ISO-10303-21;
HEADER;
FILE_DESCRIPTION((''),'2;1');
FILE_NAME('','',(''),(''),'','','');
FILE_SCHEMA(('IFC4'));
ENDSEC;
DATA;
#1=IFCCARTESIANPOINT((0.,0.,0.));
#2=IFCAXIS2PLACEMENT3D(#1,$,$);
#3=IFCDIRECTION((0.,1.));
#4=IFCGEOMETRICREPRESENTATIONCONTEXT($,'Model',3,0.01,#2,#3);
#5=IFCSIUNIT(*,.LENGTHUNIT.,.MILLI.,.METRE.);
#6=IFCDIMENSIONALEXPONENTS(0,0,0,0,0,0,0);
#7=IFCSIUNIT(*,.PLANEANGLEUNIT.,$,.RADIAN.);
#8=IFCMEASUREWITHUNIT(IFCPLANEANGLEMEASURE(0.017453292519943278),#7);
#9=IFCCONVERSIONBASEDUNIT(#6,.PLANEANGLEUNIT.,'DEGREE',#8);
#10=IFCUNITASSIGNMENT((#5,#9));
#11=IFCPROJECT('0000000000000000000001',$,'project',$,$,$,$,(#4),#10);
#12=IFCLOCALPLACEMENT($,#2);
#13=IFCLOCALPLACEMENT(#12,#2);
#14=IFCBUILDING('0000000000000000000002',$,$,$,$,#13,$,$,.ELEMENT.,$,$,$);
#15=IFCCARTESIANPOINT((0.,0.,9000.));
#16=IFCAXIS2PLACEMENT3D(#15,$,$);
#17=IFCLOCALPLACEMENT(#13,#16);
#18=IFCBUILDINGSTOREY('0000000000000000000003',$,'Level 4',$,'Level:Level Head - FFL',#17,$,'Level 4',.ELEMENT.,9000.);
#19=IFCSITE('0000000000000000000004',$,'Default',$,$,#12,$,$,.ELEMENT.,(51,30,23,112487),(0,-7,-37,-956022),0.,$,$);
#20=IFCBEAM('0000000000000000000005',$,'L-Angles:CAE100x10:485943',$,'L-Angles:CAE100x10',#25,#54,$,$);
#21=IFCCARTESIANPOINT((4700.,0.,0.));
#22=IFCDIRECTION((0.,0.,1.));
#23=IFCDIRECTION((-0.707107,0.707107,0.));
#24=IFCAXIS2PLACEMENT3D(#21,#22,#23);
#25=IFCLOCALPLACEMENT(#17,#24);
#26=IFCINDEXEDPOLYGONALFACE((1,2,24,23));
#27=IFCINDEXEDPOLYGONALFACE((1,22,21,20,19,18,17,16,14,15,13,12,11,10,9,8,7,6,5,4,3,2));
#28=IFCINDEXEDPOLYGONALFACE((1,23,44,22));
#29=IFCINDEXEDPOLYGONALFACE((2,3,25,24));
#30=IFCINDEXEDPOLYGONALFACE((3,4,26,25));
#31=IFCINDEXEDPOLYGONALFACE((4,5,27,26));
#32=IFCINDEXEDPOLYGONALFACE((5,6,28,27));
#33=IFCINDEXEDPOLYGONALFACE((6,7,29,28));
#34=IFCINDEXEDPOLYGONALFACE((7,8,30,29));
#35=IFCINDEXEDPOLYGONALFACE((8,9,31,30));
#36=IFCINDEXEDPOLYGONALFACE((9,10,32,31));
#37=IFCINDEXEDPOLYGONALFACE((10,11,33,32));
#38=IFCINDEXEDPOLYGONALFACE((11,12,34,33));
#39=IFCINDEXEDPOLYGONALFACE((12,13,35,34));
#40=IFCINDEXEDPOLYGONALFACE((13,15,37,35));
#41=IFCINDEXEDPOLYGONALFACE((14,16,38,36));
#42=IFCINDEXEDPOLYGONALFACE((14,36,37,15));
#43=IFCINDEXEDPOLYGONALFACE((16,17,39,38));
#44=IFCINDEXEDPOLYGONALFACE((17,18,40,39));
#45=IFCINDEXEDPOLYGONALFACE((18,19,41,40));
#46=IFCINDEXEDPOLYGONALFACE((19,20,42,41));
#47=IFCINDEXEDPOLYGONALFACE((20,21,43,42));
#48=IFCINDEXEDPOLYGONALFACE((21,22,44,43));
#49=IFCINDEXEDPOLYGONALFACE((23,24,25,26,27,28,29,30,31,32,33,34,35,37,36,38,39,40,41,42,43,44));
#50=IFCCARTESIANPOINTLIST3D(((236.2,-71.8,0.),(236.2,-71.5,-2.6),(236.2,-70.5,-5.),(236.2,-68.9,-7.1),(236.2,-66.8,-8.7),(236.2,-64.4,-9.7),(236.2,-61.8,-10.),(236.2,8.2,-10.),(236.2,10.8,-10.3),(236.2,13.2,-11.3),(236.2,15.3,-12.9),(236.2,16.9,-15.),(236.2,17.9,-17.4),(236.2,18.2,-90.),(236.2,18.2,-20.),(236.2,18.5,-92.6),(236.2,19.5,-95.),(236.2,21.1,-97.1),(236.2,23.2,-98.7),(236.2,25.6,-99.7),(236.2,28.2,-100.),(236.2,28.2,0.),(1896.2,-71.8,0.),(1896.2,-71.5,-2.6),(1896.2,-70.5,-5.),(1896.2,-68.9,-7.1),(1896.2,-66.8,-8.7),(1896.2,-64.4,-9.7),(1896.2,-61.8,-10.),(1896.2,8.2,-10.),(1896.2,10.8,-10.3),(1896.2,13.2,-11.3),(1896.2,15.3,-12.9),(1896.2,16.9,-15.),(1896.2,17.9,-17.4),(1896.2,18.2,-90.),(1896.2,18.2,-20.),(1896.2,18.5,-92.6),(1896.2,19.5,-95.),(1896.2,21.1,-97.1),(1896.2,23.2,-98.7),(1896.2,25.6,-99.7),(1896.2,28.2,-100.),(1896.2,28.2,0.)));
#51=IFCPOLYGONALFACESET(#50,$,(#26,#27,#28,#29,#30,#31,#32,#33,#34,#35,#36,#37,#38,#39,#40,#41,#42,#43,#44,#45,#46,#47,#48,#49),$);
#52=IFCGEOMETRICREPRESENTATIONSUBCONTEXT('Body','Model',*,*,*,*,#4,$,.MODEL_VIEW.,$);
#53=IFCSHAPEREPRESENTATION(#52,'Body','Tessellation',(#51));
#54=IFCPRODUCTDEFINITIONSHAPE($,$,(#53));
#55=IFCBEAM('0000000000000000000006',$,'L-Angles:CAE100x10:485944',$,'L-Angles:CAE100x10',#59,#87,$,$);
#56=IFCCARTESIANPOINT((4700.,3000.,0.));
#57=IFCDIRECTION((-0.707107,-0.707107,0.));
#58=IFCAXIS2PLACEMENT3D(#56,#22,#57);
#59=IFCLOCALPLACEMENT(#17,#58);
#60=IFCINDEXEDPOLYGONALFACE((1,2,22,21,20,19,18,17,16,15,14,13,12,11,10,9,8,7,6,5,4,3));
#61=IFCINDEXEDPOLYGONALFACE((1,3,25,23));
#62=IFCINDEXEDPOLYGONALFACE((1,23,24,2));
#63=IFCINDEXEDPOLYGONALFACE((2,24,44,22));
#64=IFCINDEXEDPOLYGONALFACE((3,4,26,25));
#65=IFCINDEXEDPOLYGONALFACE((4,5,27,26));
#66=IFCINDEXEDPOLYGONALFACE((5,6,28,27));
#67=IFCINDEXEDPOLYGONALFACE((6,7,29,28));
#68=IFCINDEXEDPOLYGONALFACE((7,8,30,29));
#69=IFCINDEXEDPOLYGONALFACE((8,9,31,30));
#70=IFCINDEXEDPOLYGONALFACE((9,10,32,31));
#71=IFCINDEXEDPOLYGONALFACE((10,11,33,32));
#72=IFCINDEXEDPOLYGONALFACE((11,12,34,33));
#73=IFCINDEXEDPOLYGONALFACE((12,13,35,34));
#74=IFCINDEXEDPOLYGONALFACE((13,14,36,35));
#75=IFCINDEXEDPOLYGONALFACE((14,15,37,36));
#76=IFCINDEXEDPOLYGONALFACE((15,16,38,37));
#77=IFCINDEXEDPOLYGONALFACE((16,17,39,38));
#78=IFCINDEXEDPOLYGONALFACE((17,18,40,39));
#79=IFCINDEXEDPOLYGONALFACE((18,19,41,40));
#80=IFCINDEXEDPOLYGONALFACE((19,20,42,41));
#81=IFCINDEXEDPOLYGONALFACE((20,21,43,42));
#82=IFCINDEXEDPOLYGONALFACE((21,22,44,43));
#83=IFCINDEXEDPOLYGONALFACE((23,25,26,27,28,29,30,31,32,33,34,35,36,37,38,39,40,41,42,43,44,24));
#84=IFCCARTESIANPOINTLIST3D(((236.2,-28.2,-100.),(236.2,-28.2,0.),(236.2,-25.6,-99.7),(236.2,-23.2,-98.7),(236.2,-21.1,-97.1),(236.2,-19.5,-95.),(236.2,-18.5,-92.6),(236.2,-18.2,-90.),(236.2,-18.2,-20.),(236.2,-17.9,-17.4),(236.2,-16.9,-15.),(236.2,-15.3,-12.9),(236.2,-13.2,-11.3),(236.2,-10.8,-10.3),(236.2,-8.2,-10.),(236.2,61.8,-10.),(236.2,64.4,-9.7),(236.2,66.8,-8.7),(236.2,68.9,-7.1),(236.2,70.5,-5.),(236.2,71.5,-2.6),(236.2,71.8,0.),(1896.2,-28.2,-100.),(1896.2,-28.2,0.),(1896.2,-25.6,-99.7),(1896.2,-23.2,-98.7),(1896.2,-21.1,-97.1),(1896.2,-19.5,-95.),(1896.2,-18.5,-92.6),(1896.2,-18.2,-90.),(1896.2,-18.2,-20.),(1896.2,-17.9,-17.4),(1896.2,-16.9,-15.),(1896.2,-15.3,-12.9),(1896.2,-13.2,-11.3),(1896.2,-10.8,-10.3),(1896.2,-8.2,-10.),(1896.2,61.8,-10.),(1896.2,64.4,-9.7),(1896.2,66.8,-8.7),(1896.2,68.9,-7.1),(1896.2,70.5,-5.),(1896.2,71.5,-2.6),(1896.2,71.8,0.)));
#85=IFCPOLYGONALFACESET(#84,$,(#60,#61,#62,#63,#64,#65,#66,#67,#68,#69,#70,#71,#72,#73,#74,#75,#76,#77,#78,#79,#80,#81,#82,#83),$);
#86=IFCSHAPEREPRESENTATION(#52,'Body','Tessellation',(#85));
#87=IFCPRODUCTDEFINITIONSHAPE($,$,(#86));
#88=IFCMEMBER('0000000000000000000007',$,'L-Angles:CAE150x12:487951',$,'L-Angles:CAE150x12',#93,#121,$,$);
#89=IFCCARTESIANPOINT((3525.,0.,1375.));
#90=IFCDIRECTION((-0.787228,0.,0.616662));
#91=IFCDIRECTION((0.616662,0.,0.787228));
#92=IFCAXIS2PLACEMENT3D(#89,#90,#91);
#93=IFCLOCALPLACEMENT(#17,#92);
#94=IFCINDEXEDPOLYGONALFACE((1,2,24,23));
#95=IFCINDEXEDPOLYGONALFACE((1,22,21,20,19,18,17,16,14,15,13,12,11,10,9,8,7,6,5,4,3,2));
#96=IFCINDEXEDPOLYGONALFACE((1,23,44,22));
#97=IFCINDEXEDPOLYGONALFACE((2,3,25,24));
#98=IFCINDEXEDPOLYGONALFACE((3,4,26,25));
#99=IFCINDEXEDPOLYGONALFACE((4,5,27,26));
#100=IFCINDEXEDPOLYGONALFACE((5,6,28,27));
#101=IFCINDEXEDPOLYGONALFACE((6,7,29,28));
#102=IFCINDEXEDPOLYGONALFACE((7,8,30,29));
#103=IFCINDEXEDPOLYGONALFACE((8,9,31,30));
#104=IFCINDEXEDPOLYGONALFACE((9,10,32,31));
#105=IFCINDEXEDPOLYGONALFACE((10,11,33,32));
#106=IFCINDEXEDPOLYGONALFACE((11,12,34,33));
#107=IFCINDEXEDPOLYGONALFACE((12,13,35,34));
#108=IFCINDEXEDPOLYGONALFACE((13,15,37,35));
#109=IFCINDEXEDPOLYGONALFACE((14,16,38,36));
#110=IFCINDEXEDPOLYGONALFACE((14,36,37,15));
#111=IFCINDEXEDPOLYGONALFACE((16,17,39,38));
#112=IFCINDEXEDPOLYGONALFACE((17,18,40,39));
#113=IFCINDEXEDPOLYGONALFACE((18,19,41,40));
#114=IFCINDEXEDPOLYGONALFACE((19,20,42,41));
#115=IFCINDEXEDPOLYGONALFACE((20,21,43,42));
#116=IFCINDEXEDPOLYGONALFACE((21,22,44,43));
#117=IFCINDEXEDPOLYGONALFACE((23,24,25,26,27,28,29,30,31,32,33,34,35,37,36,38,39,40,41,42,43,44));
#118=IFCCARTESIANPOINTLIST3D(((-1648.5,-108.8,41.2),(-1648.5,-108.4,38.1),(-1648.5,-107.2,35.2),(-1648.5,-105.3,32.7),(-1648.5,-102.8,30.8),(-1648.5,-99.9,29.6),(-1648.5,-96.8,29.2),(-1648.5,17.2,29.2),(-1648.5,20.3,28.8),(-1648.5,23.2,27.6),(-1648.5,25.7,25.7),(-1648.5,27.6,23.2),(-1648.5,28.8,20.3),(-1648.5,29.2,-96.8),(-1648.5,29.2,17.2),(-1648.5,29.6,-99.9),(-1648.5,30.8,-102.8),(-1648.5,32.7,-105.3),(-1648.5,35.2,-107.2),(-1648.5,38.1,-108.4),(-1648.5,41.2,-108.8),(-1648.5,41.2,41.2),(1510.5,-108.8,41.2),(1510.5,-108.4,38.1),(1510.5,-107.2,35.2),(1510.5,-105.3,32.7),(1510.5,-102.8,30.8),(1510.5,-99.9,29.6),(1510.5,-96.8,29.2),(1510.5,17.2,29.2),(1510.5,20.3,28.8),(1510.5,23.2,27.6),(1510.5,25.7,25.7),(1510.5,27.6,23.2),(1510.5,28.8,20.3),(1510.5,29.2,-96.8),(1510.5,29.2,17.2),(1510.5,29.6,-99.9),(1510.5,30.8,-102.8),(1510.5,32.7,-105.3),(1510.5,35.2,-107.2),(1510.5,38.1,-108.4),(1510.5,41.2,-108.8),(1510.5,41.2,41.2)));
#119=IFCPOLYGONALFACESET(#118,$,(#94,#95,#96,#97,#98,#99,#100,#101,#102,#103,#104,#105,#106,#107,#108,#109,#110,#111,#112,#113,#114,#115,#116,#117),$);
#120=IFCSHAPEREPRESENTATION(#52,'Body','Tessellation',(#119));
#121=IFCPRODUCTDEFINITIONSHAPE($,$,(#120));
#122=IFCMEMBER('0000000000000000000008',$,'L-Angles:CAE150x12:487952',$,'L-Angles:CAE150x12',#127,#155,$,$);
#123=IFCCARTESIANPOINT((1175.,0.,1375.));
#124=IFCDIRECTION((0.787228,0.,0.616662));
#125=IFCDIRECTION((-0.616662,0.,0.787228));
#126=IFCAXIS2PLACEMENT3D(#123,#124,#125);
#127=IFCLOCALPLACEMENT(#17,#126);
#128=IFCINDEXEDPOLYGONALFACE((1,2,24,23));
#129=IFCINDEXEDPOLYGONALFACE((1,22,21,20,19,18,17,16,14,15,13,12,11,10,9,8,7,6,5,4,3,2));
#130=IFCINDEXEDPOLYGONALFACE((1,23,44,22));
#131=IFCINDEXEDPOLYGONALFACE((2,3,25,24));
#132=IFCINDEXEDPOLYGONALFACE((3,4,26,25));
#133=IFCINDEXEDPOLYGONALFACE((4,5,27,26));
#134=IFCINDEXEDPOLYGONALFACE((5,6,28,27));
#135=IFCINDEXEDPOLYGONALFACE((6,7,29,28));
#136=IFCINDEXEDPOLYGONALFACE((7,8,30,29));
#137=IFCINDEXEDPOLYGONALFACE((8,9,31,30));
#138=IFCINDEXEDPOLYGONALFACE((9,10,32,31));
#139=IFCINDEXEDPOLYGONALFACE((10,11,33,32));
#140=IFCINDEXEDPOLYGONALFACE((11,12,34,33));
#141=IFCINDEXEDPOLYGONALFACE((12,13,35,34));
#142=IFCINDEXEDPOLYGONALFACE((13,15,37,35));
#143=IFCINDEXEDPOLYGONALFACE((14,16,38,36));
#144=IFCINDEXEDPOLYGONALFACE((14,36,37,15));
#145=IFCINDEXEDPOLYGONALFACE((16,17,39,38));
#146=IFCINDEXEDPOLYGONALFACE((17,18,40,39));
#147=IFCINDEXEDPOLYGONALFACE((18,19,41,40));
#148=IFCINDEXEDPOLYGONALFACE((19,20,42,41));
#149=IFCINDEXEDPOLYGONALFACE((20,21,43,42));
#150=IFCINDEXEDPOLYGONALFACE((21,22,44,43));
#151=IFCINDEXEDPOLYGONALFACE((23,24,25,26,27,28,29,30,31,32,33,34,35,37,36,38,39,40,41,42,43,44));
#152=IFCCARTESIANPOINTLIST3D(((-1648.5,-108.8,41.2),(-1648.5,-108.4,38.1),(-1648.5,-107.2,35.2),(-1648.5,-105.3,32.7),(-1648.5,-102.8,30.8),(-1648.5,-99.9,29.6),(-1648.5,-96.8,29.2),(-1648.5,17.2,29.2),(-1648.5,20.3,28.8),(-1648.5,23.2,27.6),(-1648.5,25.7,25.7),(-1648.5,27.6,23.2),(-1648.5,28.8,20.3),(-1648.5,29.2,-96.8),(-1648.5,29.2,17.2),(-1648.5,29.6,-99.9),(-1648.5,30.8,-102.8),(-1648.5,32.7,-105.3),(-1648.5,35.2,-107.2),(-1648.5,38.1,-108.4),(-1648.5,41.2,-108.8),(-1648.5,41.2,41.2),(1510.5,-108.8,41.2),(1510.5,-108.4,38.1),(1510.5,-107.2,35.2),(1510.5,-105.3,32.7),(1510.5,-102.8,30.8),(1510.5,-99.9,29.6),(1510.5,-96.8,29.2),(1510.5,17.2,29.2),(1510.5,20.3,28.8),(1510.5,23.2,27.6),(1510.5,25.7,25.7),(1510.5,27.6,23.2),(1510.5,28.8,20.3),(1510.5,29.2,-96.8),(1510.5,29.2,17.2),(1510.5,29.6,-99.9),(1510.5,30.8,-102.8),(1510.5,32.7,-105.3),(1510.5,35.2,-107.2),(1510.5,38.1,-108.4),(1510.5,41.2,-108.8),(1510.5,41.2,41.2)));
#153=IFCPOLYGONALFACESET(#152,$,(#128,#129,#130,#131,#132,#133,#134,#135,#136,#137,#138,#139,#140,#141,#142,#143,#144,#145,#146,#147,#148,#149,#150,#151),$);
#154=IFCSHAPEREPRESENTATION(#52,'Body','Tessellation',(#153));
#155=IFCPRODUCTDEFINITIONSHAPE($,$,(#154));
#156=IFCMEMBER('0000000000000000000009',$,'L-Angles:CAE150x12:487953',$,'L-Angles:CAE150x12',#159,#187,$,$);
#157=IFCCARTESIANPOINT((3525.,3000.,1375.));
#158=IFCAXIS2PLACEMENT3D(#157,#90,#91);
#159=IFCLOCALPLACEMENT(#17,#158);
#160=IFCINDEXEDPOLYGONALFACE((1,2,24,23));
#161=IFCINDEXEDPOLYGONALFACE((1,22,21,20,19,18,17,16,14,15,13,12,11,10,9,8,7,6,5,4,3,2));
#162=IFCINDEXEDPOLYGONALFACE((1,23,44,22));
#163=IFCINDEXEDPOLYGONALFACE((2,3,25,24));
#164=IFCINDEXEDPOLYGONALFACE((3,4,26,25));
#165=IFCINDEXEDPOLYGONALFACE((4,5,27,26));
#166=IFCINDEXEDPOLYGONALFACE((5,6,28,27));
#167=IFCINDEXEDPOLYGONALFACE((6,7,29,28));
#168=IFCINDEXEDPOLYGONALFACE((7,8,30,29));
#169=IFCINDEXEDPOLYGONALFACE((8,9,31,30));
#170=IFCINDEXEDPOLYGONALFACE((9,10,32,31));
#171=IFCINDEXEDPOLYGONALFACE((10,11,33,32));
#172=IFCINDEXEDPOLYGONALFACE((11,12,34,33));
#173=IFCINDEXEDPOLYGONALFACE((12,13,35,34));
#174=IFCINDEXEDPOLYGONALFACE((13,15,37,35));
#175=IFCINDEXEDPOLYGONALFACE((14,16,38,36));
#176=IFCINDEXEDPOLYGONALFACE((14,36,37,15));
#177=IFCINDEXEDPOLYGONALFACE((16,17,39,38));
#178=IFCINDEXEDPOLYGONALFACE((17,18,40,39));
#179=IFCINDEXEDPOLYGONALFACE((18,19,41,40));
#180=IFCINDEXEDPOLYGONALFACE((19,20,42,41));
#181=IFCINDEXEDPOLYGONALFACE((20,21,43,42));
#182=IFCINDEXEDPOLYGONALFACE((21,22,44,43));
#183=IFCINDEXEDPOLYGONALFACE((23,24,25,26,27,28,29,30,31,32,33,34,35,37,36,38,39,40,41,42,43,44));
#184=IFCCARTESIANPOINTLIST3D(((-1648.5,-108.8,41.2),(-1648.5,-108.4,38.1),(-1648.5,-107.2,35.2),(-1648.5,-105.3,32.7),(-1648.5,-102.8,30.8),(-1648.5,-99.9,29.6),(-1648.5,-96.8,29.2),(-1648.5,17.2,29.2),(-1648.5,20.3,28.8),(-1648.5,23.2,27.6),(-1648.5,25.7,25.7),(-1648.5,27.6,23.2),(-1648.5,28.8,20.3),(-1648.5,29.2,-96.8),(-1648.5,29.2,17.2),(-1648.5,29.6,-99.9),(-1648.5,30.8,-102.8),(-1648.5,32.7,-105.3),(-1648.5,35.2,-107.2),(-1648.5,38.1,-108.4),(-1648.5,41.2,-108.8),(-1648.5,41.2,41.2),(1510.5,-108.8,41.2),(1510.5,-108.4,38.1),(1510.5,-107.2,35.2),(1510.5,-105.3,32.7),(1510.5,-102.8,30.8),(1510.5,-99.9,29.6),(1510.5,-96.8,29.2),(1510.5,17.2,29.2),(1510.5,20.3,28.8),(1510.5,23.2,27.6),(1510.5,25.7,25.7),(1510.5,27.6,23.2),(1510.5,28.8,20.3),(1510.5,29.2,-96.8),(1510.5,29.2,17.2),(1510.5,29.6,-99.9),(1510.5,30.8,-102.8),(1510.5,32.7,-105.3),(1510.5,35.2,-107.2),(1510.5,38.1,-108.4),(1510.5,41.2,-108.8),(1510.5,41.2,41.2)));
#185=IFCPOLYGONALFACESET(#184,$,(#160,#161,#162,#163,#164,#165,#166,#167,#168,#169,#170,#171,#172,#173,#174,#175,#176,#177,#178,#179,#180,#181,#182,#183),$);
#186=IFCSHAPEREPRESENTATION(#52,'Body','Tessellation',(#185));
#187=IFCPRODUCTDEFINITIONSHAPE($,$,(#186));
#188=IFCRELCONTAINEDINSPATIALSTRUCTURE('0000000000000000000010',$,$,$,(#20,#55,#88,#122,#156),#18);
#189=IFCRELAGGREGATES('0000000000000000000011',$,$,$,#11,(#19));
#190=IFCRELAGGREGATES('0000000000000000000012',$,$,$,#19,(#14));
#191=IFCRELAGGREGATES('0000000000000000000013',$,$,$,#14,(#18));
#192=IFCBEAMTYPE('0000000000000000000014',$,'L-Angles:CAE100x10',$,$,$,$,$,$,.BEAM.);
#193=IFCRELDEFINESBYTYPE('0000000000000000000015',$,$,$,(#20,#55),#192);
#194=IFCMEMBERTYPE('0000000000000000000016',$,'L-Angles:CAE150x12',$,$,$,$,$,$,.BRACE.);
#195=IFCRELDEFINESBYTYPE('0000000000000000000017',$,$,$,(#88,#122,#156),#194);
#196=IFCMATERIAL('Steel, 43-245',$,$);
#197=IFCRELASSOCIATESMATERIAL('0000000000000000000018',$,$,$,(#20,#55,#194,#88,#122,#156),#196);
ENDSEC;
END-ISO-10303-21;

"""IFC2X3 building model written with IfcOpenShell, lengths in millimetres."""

from ifc_helpers import new_model, entity, si_unit, converted_unit, direction, frame, frame_2d, origin, place, context, subcontext, project, spatial, polyline, circle_curve, parameter, trimmed, segment, composite_curve, outline, extrude, source, transform, mapped, material, type_object, type_shapes, element, save


model = new_model("IFC2X3")

# Units and contexts
model_context = context("Model", 3, precision=0.01, world=origin(), true_north=direction((0.0, 1.0)))
body_context = subcontext(model_context, "Body", "Model", "MODEL_VIEW")
ifc_project = project(units=[si_unit("LENGTHUNIT", "METRE", prefix="MILLI"), converted_unit("PLANEANGLEUNIT", "DEGREE", entity("IfcPlaneAngleMeasure", 0.017453292519943278), si_unit("PLANEANGLEUNIT", "RADIAN"), dimensions=[0, 0, 0, 0, 0, 0, 0])], contexts=[model_context])

# Site, building, storey
site_placement = place(None, origin())
site = spatial("IfcSite", under=ifc_project, at=site_placement, Name="Default", CompositionType="ELEMENT", RefLatitude=(51, 30, 23, 112487), RefLongitude=(0, -7, -37, -956022), RefElevation=0.0)
building_placement = place(site_placement, origin())
building = spatial("IfcBuilding", under=site, at=building_placement, CompositionType="ELEMENT")
storey_placement = place(building_placement, frame((0.0, 0.0, 9000.0)))
storey = spatial("IfcBuildingStorey", under=building, at=storey_placement, Name="Level 4", ObjectType="Level:Level Head - FFL", LongName="Level 4", CompositionType="ELEMENT", Elevation=9000.0)

# Beams
ifc_material = material(Name="Steel, 43-245")
beam_type_1 = type_object("IfcBeamType", Name="L-Angles:CAE100x10", PredefinedType="BEAM")
beam_1_placement = place(storey_placement, frame((4700.0, 0.0, 0.0), z_axis=(0.0, 0.0, 1.0), x_axis=(-0.707107, 0.707107, 0.0)))
element("IfcBeam", 1, at=beam_1_placement, inside=storey, type_object=beam_type_1, material=ifc_material, Name="L-Angles:CAE100x10:485943", ObjectType="L-Angles:CAE100x10", context=body_context, shape_type="SweptSolid", body=[
    extrude(outline(composite_curve([segment(polyline([(-67.1, -32.9), (32.9, -32.9)]), True, "CONTINUOUS"), segment(polyline([(32.9, -32.9), (32.9, 67.1)]), True, "CONTINUOUS"), segment(trimmed(circle_curve(frame_2d((32.9, 57.1), x_axis=(0.0, 1.0)), 10.0), [parameter(0.0)], [parameter(90.0)], True, "PARAMETER"), True, "CONTINUOUS"), segment(polyline([(22.9, 57.1), (22.9, -12.9)]), True, "CONTINUOUS"), segment(trimmed(circle_curve(frame_2d((12.9, -12.9), x_axis=(1.0, 0.0)), 10.0), [parameter(270.0)], [parameter(0.0)], True, "PARAMETER"), False, "CONTINUOUS"), segment(polyline([(12.9, -22.9), (-57.1, -22.9)]), True, "CONTINUOUS"), segment(trimmed(circle_curve(frame_2d((-57.1, -32.9), x_axis=(0.0, 1.0)), 10.0), [parameter(0.0)], [parameter(90.0)], True, "PARAMETER"), True, "CONTINUOUS")], self_intersect=False)), frame((236.2, -4.7, -32.9), z_axis=(1.0, 0.0, 0.0), x_axis=(0.0, 0.0, 1.0)), (0.0, 0.0, 1.0), 1660.0),
])
beam_2_placement = place(storey_placement, frame((4700.0, 3000.0, 0.0), z_axis=(0.0, 0.0, 1.0), x_axis=(-0.707107, -0.707107, 0.0)))
element("IfcBeam", 2, at=beam_2_placement, inside=storey, type_object=beam_type_1, material=ifc_material, Name="L-Angles:CAE100x10:485944", ObjectType="L-Angles:CAE100x10", context=body_context, shape_type="SweptSolid", body=[
    extrude(outline(composite_curve([segment(polyline([(-32.9, -32.9), (67.1, -32.9)]), True, "CONTINUOUS"), segment(trimmed(circle_curve(frame_2d((57.1, -32.9), x_axis=(1.0, 0.0)), 10.0), [parameter(0.0)], [parameter(90.0)], True, "PARAMETER"), True, "CONTINUOUS"), segment(polyline([(57.1, -22.9), (-12.9, -22.9)]), True, "CONTINUOUS"), segment(trimmed(circle_curve(frame_2d((-12.9, -12.9), x_axis=(0.0, -1.0)), 10.0), [parameter(270.0)], [parameter(0.0)], True, "PARAMETER"), False, "CONTINUOUS"), segment(polyline([(-22.9, -12.9), (-22.9, 57.1)]), True, "CONTINUOUS"), segment(trimmed(circle_curve(frame_2d((-32.9, 57.1), x_axis=(1.0, 0.0)), 10.0), [parameter(0.0)], [parameter(90.0)], True, "PARAMETER"), True, "CONTINUOUS"), segment(polyline([(-32.9, 67.1), (-32.9, -32.9)]), True, "CONTINUOUS")], self_intersect=False)), frame((236.2, 4.7, -32.9), z_axis=(1.0, 0.0, 0.0), x_axis=(0.0, 0.0, -1.0)), (0.0, 0.0, 1.0), 1660.0),
])

# Members
member_type_1 = type_object("IfcMemberType", Name="L-Angles:CAE150x12", PredefinedType="BRACE", material=ifc_material)
shared_shape_1 = source(origin(), body_context, "Body", "SweptSolid", [
    extrude(outline(composite_curve([segment(polyline([(-102.0, -48.0), (48.0, -48.0)]), True, "CONTINUOUS"), segment(polyline([(48.0, -48.0), (48.0, 102.0)]), True, "CONTINUOUS"), segment(trimmed(circle_curve(frame_2d((48.0, 90.0), x_axis=(0.0, 1.0)), 12.0), [parameter(0.0)], [parameter(90.0)], True, "PARAMETER"), True, "CONTINUOUS"), segment(polyline([(36.0, 90.0), (36.0, -24.0)]), True, "CONTINUOUS"), segment(trimmed(circle_curve(frame_2d((24.0, -24.0), x_axis=(1.0, 0.0)), 12.0), [parameter(270.0)], [parameter(0.0)], True, "PARAMETER"), False, "CONTINUOUS"), segment(polyline([(24.0, -36.0), (-90.0, -36.0)]), True, "CONTINUOUS"), segment(trimmed(circle_curve(frame_2d((-90.0, -48.0), x_axis=(0.0, 1.0)), 12.0), [parameter(0.0)], [parameter(90.0)], True, "PARAMETER"), True, "CONTINUOUS")], self_intersect=False)), frame((-1648.5, -6.8, -6.8), z_axis=(1.0, 0.0, 0.0), x_axis=(0.0, 0.0, 1.0)), (0.0, 0.0, 1.0), 3159.0),
])
type_shapes(member_type_1, [shared_shape_1])
for number, where, z_axis, x_axis, name in (
    (3, (3525.0, 0.0, 1375.0), (-0.787228, 0.0, 0.616662), (0.616662, 0.0, 0.787228), "L-Angles:CAE150x12:487951"),
    (4, (1175.0, 0.0, 1375.0), (0.787228, 0.0, 0.616662), (-0.616662, 0.0, 0.787228), "L-Angles:CAE150x12:487952"),
    (5, (3525.0, 3000.0, 1375.0), (-0.787228, 0.0, 0.616662), (0.616662, 0.0, 0.787228), "L-Angles:CAE150x12:487953"),
):
    element("IfcMember", number, at=place(storey_placement, frame(where, z_axis=z_axis, x_axis=x_axis)), inside=storey, type_object=member_type_1, material=ifc_material, Name=name, ObjectType="L-Angles:CAE150x12", context=body_context, shape_type="MappedRepresentation", body=[
        mapped(shared_shape_1, transform((0.0, 0.0, 0.0), scale=1.0)),
    ])

save(model, "model.ifc")
